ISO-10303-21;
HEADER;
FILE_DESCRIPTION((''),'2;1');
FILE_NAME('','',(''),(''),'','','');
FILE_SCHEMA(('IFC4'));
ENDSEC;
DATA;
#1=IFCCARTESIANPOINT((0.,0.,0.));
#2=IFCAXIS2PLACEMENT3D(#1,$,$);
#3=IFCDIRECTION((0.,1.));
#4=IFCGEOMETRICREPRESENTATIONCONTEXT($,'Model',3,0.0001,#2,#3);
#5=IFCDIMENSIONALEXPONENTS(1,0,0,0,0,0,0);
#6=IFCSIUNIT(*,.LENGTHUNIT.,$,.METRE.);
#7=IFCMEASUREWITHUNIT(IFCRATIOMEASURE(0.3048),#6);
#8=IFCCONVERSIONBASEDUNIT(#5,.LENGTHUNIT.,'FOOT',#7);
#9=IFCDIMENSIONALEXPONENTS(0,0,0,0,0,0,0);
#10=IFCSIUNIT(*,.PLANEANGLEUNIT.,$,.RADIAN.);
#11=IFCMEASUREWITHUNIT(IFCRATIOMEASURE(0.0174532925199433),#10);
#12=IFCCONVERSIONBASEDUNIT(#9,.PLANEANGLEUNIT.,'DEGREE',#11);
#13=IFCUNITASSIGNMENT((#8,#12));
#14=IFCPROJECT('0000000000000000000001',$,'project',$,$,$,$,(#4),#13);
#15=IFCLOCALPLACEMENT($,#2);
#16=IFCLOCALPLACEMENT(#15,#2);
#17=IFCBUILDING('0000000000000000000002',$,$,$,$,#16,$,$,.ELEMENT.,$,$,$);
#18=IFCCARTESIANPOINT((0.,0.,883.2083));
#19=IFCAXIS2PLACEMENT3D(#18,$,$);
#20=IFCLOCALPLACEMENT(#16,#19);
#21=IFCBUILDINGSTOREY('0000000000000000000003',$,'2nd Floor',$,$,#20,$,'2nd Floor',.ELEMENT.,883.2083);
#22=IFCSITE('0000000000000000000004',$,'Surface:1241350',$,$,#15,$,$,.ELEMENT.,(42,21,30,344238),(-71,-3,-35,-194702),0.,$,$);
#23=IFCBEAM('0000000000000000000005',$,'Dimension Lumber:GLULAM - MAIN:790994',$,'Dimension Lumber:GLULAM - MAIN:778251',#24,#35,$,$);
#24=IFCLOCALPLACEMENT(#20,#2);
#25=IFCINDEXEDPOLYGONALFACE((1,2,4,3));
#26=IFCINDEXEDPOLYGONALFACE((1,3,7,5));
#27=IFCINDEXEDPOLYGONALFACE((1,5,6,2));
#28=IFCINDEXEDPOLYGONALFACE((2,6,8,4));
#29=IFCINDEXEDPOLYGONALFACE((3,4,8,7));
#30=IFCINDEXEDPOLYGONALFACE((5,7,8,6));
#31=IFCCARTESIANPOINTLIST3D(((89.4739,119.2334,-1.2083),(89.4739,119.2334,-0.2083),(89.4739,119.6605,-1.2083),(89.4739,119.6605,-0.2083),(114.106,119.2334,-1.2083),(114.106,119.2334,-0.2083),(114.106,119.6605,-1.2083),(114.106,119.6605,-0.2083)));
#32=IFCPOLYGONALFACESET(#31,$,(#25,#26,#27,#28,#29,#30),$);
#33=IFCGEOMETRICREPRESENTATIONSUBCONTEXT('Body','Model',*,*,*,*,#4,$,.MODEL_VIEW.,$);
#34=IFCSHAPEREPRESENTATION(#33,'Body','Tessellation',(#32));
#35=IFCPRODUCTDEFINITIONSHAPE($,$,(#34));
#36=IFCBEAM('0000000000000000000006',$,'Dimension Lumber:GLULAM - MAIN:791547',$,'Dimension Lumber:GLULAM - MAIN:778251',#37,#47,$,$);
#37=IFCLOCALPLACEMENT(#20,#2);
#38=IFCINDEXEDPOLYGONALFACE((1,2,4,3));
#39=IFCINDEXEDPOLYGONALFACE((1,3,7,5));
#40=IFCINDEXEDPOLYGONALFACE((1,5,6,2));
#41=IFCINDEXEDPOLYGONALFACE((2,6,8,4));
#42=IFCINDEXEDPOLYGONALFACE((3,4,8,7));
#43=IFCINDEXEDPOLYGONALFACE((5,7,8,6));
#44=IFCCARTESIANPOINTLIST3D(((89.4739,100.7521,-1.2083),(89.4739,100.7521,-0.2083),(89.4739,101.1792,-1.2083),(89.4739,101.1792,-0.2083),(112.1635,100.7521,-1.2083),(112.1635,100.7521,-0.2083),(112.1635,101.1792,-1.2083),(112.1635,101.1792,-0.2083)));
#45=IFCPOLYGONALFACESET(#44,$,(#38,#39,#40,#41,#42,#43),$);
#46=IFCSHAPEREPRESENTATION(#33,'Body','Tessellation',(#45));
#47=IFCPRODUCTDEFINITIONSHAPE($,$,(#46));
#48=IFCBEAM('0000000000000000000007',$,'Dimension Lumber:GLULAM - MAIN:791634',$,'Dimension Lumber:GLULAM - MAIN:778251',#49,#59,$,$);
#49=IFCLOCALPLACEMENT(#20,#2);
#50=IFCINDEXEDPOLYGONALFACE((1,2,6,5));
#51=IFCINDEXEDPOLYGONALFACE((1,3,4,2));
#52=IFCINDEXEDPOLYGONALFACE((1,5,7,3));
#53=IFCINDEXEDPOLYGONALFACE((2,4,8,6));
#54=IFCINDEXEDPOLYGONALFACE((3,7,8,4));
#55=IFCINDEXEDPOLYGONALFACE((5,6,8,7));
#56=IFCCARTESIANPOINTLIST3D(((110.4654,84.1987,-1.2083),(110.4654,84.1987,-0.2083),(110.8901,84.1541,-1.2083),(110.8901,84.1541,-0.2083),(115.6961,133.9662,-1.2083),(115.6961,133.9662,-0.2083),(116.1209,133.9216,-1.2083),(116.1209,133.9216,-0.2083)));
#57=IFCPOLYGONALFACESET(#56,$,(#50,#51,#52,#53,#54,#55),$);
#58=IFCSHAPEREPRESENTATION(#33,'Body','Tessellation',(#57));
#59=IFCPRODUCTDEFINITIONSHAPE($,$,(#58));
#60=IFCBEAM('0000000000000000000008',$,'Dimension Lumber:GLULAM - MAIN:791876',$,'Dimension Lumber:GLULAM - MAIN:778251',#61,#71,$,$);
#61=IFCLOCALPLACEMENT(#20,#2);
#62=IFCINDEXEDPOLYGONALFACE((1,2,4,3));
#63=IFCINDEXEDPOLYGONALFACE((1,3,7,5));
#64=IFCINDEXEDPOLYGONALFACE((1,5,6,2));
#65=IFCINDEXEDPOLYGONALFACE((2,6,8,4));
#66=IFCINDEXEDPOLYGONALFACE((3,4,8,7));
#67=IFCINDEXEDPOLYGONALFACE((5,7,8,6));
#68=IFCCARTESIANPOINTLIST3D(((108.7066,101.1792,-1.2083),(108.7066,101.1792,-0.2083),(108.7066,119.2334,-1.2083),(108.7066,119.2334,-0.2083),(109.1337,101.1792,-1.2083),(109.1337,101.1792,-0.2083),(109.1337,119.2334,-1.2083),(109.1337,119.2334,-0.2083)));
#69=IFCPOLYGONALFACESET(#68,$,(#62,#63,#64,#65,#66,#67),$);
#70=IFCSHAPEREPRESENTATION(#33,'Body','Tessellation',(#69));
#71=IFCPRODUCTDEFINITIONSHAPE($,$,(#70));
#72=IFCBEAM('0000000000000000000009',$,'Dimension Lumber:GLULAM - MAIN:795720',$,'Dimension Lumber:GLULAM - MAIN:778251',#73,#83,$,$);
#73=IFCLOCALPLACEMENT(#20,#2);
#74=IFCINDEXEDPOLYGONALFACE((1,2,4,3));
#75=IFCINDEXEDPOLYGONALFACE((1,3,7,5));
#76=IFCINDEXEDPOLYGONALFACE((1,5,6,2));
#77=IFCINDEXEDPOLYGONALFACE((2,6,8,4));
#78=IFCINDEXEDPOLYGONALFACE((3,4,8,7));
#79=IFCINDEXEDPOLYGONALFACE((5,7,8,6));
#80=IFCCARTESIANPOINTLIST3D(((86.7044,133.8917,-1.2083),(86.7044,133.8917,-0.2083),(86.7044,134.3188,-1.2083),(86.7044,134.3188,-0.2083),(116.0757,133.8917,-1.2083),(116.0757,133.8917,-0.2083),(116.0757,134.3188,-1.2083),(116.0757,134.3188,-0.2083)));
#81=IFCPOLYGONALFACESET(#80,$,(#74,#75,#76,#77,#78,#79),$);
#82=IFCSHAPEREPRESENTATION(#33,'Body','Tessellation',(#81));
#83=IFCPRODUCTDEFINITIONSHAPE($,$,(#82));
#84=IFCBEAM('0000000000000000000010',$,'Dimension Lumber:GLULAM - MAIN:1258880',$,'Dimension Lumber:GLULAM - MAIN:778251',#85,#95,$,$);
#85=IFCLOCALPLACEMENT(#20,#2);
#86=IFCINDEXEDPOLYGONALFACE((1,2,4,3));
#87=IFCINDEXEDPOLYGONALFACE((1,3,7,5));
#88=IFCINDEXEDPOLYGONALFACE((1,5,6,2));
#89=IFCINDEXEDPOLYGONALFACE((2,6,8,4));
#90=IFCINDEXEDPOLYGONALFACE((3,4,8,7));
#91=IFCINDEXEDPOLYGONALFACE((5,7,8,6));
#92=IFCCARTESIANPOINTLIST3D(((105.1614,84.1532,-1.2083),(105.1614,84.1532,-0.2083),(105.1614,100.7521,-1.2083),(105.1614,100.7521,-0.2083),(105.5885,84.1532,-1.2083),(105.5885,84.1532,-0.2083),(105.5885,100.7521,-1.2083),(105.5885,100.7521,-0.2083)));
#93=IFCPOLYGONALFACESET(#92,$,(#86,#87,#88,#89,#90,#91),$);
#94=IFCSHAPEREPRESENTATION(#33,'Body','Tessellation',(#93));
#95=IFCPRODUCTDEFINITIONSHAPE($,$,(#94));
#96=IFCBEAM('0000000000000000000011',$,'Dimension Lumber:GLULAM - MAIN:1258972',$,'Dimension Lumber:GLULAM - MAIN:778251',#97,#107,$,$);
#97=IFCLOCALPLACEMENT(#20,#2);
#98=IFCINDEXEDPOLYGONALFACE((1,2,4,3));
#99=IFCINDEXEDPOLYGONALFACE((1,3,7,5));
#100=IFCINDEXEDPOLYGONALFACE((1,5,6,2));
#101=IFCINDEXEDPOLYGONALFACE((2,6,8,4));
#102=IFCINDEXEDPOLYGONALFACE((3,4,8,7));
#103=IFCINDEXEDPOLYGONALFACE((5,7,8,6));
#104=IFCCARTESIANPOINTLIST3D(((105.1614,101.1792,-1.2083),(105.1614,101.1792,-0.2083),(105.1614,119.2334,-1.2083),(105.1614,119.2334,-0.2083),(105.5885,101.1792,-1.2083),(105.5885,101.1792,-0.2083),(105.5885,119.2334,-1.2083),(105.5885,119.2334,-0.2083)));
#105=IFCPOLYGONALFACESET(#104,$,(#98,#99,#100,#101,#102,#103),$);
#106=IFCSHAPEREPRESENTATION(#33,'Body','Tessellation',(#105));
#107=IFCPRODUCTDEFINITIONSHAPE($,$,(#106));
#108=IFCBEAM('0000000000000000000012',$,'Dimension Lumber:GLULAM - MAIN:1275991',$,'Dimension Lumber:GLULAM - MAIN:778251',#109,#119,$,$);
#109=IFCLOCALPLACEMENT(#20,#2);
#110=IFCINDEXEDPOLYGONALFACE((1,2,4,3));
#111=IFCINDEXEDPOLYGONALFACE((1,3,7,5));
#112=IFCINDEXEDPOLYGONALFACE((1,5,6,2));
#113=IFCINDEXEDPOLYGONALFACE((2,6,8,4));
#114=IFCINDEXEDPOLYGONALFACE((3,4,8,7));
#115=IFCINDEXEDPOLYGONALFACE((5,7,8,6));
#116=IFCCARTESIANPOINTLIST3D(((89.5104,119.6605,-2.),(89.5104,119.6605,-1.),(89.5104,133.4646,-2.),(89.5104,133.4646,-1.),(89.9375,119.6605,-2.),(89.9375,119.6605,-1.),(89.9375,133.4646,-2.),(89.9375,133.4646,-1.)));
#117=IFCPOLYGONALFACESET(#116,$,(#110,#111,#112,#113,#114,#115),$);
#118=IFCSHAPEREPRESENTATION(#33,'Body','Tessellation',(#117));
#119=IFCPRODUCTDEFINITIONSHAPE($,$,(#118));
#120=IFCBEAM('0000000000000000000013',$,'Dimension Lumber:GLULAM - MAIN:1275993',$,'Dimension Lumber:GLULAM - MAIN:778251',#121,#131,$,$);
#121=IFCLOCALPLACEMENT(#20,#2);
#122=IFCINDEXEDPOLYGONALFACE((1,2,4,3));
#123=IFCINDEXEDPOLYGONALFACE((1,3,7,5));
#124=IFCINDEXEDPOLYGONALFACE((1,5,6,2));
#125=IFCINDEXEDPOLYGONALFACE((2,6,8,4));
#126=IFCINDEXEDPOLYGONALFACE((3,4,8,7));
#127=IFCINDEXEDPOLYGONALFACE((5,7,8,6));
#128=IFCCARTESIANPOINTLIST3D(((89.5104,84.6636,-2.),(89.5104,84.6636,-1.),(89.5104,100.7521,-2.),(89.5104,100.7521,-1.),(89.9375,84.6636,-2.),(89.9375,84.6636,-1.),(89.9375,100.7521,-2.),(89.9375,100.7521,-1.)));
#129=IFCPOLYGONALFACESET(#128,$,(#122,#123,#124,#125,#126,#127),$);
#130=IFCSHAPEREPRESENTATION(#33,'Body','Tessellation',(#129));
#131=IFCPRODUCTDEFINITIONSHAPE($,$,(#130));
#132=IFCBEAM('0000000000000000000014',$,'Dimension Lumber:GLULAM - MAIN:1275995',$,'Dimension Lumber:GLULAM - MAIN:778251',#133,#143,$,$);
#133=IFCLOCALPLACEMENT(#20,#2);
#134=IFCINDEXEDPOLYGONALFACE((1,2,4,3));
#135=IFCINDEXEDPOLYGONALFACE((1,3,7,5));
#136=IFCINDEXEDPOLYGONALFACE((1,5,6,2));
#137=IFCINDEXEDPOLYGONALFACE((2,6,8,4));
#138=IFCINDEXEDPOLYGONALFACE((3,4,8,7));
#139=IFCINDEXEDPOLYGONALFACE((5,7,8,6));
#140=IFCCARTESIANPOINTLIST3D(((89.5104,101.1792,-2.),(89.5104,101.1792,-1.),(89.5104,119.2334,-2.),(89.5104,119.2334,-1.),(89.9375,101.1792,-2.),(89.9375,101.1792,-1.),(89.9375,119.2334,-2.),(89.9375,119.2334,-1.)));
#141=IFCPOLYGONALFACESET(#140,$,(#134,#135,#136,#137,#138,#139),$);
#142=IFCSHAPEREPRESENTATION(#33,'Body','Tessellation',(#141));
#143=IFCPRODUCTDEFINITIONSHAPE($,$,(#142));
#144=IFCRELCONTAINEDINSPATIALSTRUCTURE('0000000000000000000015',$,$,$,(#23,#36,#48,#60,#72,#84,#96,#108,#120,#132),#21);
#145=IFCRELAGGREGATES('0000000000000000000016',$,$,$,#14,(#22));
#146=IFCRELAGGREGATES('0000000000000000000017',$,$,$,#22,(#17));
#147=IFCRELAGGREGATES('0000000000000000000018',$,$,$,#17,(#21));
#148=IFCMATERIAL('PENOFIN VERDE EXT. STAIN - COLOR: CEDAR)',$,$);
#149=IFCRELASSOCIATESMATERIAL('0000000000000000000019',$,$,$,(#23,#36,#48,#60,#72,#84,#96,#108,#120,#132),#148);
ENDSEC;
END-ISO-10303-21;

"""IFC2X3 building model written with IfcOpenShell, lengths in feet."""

from ifc_helpers import new_model, entity, si_unit, converted_unit, direction, frame, frame_2d, origin, origin_2d_with_axis, place, context, subcontext, project, spatial, rectangle, extrude, material, element, save


model = new_model("IFC2X3")

# Units and contexts
model_context = context("Model", 3, precision=0.0001, world=origin(), true_north=direction((0.0, 1.0)))
body_context = subcontext(model_context, "Body", "Model", "MODEL_VIEW")
ifc_project = project(units=[converted_unit("LENGTHUNIT", "FOOT", entity("IfcRatioMeasure", 0.3048), si_unit("LENGTHUNIT", "METRE"), dimensions=[1, 0, 0, 0, 0, 0, 0]), converted_unit("PLANEANGLEUNIT", "DEGREE", entity("IfcRatioMeasure", 0.0174532925199433), si_unit("PLANEANGLEUNIT", "RADIAN"), dimensions=[0, 0, 0, 0, 0, 0, 0])], contexts=[model_context])

# Site, building, storey
site_placement = place(None, origin())
site = spatial("IfcSite", under=ifc_project, at=site_placement, Name="Surface:1241350", CompositionType="ELEMENT", RefLatitude=(42, 21, 30, 344238), RefLongitude=(-71, -3, -35, -194702), RefElevation=0.0)
building_placement = place(site_placement, origin())
building = spatial("IfcBuilding", under=site, at=building_placement, CompositionType="ELEMENT")
storey_placement = place(building_placement, frame((0.0, 0.0, 883.2083)))
storey = spatial("IfcBuildingStorey", under=building, at=storey_placement, Name="2nd Floor", LongName="2nd Floor", CompositionType="ELEMENT", Elevation=883.2083)

# Beams
ifc_material_1 = material(Name="PENOFIN VERDE EXT. STAIN - COLOR: CEDAR)")
beam_1_placement = place(storey_placement, frame((89.4739, 119.4469, 0.0)))
element("IfcBeam", 1, at=beam_1_placement, inside=storey, material=ifc_material_1, Name="Dimension Lumber:GLULAM - MAIN:790994", ObjectType="Dimension Lumber:GLULAM - MAIN:778251", context=body_context, shape_type="SweptSolid", body=[
    extrude(rectangle(XDim=1.0, YDim=0.4271, at=frame_2d((0.0, 0.0), x_axis=(1.0, 0.0))), frame((0.0, 0.0, -0.7083), z_axis=(1.0, 0.0, 0.0), x_axis=(0.0, 0.0, -1.0)), (0.0, 0.0, 1.0), 24.632),
])
beam_2_placement = place(storey_placement, frame((89.4739, 100.9657, 0.0)))
element("IfcBeam", 2, at=beam_2_placement, inside=storey, material=ifc_material_1, Name="Dimension Lumber:GLULAM - MAIN:791547", ObjectType="Dimension Lumber:GLULAM - MAIN:778251", context=body_context, shape_type="SweptSolid", body=[
    extrude(rectangle(XDim=1.0, YDim=0.4271, at=frame_2d((0.0, 0.0), x_axis=(1.0, 0.0))), frame((0.0, 0.0, -0.7083), z_axis=(1.0, 0.0, 0.0), x_axis=(0.0, 0.0, -1.0)), (0.0, 0.0, 1.0), 22.6896),
])
beam_3_placement = place(storey_placement, frame((110.6777, 84.1764, 0.0), z_axis=(0.0, 0.0, 1.0), x_axis=(0.104528, 0.994522, 0.0)))
element("IfcBeam", 3, at=beam_3_placement, inside=storey, material=ifc_material_1, Name="Dimension Lumber:GLULAM - MAIN:791634", ObjectType="Dimension Lumber:GLULAM - MAIN:778251", context=body_context, shape_type="SweptSolid", body=[
    extrude(rectangle(XDim=1.0, YDim=0.4271, at=origin_2d_with_axis()), frame((0.0, 0.0, -0.7083), z_axis=(1.0, 0.0, 0.0), x_axis=(0.0, 0.0, -1.0)), (0.0, 0.0, 1.0), 50.0417),
])
beam_4_placement = place(storey_placement, frame((108.9201, 101.1792, 0.0), z_axis=(0.0, 0.0, 1.0), x_axis=(0.0, 1.0, 0.0)))
element("IfcBeam", 4, at=beam_4_placement, inside=storey, material=ifc_material_1, Name="Dimension Lumber:GLULAM - MAIN:791876", ObjectType="Dimension Lumber:GLULAM - MAIN:778251", context=body_context, shape_type="SweptSolid", body=[
    extrude(rectangle(XDim=1.0, YDim=0.4271, at=frame_2d((0.0, 0.0), x_axis=(1.0, 0.0))), frame((0.0, 0.0, -0.7083), z_axis=(1.0, 0.0, 0.0), x_axis=(0.0, 0.0, -1.0)), (0.0, 0.0, 1.0), 18.0542),
])
beam_5_placement = place(storey_placement, frame((86.7044, 134.1053, 0.0)))
element("IfcBeam", 5, at=beam_5_placement, inside=storey, material=ifc_material_1, Name="Dimension Lumber:GLULAM - MAIN:795720", ObjectType="Dimension Lumber:GLULAM - MAIN:778251", context=body_context, shape_type="SweptSolid", body=[
    extrude(rectangle(XDim=1.0, YDim=0.4271, at=frame_2d((0.0, 0.0), x_axis=(1.0, 0.0))), frame((0.0, 0.0, -0.7083), z_axis=(1.0, 0.0, 0.0), x_axis=(0.0, 0.0, -1.0)), (0.0, 0.0, 1.0), 29.3714),
])
beam_6_placement = place(storey_placement, frame((105.375, 100.7521, 0.0), z_axis=(0.0, 0.0, 1.0), x_axis=(0.0, -1.0, 0.0)))
element("IfcBeam", 6, at=beam_6_placement, inside=storey, material=ifc_material_1, Name="Dimension Lumber:GLULAM - MAIN:1258880", ObjectType="Dimension Lumber:GLULAM - MAIN:778251", context=body_context, shape_type="SweptSolid", body=[
    extrude(rectangle(XDim=1.0, YDim=0.4271, at=frame_2d((0.0, 0.0), x_axis=(1.0, 0.0))), frame((0.0, 0.0, -0.7083), z_axis=(1.0, 0.0, 0.0), x_axis=(0.0, 0.0, -1.0)), (0.0, 0.0, 1.0), 16.599),
])
beam_7_placement = place(storey_placement, frame((105.375, 119.2334, 0.0), z_axis=(0.0, 0.0, 1.0), x_axis=(0.0, -1.0, 0.0)))
element("IfcBeam", 7, at=beam_7_placement, inside=storey, material=ifc_material_1, Name="Dimension Lumber:GLULAM - MAIN:1258972", ObjectType="Dimension Lumber:GLULAM - MAIN:778251", context=body_context, shape_type="SweptSolid", body=[
    extrude(rectangle(XDim=1.0, YDim=0.4271, at=origin_2d_with_axis()), frame((0.0, 0.0, -0.7083), z_axis=(1.0, 0.0, 0.0), x_axis=(0.0, 0.0, -1.0)), (0.0, 0.0, 1.0), 18.0542),
])
beam_8_placement = place(storey_placement, frame((89.7239, 133.4646, 0.0), z_axis=(0.0, 0.0, 1.0), x_axis=(0.0, -1.0, 0.0)))
element("IfcBeam", 8, at=beam_8_placement, inside=storey, material=ifc_material_1, Name="Dimension Lumber:GLULAM - MAIN:1275991", ObjectType="Dimension Lumber:GLULAM - MAIN:778251", context=body_context, shape_type="SweptSolid", body=[
    extrude(rectangle(XDim=1.0, YDim=0.4271, at=origin_2d_with_axis()), frame((0.0, 0.0, -1.5), z_axis=(1.0, 0.0, 0.0), x_axis=(0.0, 0.0, -1.0)), (0.0, 0.0, 1.0), 13.8042),
])
beam_9_placement = place(storey_placement, frame((89.7239, 100.9657, 0.0), z_axis=(0.0, 0.0, 1.0), x_axis=(0.0, -1.0, 0.0)))
element("IfcBeam", 9, at=beam_9_placement, inside=storey, material=ifc_material_1, Name="Dimension Lumber:GLULAM - MAIN:1275993", ObjectType="Dimension Lumber:GLULAM - MAIN:778251", context=body_context, shape_type="SweptSolid", body=[
    extrude(rectangle(XDim=1.0, YDim=0.4271, at=origin_2d_with_axis()), frame((0.2135, 0.0, -1.5), z_axis=(1.0, 0.0, 0.0), x_axis=(0.0, 0.0, -1.0)), (0.0, 0.0, 1.0), 16.0885),
])
beam_10_placement = place(storey_placement, frame((89.7239, 119.2334, 0.0), z_axis=(0.0, 0.0, 1.0), x_axis=(0.0, -1.0, 0.0)))
element("IfcBeam", 10, at=beam_10_placement, inside=storey, material=ifc_material_1, Name="Dimension Lumber:GLULAM - MAIN:1275995", ObjectType="Dimension Lumber:GLULAM - MAIN:778251", context=body_context, shape_type="SweptSolid", body=[
    extrude(rectangle(XDim=1.0, YDim=0.4271, at=origin_2d_with_axis()), frame((0.0, 0.0, -1.5), z_axis=(1.0, 0.0, 0.0), x_axis=(0.0, 0.0, -1.0)), (0.0, 0.0, 1.0), 18.0542),
])

save(model, "model.ifc")
